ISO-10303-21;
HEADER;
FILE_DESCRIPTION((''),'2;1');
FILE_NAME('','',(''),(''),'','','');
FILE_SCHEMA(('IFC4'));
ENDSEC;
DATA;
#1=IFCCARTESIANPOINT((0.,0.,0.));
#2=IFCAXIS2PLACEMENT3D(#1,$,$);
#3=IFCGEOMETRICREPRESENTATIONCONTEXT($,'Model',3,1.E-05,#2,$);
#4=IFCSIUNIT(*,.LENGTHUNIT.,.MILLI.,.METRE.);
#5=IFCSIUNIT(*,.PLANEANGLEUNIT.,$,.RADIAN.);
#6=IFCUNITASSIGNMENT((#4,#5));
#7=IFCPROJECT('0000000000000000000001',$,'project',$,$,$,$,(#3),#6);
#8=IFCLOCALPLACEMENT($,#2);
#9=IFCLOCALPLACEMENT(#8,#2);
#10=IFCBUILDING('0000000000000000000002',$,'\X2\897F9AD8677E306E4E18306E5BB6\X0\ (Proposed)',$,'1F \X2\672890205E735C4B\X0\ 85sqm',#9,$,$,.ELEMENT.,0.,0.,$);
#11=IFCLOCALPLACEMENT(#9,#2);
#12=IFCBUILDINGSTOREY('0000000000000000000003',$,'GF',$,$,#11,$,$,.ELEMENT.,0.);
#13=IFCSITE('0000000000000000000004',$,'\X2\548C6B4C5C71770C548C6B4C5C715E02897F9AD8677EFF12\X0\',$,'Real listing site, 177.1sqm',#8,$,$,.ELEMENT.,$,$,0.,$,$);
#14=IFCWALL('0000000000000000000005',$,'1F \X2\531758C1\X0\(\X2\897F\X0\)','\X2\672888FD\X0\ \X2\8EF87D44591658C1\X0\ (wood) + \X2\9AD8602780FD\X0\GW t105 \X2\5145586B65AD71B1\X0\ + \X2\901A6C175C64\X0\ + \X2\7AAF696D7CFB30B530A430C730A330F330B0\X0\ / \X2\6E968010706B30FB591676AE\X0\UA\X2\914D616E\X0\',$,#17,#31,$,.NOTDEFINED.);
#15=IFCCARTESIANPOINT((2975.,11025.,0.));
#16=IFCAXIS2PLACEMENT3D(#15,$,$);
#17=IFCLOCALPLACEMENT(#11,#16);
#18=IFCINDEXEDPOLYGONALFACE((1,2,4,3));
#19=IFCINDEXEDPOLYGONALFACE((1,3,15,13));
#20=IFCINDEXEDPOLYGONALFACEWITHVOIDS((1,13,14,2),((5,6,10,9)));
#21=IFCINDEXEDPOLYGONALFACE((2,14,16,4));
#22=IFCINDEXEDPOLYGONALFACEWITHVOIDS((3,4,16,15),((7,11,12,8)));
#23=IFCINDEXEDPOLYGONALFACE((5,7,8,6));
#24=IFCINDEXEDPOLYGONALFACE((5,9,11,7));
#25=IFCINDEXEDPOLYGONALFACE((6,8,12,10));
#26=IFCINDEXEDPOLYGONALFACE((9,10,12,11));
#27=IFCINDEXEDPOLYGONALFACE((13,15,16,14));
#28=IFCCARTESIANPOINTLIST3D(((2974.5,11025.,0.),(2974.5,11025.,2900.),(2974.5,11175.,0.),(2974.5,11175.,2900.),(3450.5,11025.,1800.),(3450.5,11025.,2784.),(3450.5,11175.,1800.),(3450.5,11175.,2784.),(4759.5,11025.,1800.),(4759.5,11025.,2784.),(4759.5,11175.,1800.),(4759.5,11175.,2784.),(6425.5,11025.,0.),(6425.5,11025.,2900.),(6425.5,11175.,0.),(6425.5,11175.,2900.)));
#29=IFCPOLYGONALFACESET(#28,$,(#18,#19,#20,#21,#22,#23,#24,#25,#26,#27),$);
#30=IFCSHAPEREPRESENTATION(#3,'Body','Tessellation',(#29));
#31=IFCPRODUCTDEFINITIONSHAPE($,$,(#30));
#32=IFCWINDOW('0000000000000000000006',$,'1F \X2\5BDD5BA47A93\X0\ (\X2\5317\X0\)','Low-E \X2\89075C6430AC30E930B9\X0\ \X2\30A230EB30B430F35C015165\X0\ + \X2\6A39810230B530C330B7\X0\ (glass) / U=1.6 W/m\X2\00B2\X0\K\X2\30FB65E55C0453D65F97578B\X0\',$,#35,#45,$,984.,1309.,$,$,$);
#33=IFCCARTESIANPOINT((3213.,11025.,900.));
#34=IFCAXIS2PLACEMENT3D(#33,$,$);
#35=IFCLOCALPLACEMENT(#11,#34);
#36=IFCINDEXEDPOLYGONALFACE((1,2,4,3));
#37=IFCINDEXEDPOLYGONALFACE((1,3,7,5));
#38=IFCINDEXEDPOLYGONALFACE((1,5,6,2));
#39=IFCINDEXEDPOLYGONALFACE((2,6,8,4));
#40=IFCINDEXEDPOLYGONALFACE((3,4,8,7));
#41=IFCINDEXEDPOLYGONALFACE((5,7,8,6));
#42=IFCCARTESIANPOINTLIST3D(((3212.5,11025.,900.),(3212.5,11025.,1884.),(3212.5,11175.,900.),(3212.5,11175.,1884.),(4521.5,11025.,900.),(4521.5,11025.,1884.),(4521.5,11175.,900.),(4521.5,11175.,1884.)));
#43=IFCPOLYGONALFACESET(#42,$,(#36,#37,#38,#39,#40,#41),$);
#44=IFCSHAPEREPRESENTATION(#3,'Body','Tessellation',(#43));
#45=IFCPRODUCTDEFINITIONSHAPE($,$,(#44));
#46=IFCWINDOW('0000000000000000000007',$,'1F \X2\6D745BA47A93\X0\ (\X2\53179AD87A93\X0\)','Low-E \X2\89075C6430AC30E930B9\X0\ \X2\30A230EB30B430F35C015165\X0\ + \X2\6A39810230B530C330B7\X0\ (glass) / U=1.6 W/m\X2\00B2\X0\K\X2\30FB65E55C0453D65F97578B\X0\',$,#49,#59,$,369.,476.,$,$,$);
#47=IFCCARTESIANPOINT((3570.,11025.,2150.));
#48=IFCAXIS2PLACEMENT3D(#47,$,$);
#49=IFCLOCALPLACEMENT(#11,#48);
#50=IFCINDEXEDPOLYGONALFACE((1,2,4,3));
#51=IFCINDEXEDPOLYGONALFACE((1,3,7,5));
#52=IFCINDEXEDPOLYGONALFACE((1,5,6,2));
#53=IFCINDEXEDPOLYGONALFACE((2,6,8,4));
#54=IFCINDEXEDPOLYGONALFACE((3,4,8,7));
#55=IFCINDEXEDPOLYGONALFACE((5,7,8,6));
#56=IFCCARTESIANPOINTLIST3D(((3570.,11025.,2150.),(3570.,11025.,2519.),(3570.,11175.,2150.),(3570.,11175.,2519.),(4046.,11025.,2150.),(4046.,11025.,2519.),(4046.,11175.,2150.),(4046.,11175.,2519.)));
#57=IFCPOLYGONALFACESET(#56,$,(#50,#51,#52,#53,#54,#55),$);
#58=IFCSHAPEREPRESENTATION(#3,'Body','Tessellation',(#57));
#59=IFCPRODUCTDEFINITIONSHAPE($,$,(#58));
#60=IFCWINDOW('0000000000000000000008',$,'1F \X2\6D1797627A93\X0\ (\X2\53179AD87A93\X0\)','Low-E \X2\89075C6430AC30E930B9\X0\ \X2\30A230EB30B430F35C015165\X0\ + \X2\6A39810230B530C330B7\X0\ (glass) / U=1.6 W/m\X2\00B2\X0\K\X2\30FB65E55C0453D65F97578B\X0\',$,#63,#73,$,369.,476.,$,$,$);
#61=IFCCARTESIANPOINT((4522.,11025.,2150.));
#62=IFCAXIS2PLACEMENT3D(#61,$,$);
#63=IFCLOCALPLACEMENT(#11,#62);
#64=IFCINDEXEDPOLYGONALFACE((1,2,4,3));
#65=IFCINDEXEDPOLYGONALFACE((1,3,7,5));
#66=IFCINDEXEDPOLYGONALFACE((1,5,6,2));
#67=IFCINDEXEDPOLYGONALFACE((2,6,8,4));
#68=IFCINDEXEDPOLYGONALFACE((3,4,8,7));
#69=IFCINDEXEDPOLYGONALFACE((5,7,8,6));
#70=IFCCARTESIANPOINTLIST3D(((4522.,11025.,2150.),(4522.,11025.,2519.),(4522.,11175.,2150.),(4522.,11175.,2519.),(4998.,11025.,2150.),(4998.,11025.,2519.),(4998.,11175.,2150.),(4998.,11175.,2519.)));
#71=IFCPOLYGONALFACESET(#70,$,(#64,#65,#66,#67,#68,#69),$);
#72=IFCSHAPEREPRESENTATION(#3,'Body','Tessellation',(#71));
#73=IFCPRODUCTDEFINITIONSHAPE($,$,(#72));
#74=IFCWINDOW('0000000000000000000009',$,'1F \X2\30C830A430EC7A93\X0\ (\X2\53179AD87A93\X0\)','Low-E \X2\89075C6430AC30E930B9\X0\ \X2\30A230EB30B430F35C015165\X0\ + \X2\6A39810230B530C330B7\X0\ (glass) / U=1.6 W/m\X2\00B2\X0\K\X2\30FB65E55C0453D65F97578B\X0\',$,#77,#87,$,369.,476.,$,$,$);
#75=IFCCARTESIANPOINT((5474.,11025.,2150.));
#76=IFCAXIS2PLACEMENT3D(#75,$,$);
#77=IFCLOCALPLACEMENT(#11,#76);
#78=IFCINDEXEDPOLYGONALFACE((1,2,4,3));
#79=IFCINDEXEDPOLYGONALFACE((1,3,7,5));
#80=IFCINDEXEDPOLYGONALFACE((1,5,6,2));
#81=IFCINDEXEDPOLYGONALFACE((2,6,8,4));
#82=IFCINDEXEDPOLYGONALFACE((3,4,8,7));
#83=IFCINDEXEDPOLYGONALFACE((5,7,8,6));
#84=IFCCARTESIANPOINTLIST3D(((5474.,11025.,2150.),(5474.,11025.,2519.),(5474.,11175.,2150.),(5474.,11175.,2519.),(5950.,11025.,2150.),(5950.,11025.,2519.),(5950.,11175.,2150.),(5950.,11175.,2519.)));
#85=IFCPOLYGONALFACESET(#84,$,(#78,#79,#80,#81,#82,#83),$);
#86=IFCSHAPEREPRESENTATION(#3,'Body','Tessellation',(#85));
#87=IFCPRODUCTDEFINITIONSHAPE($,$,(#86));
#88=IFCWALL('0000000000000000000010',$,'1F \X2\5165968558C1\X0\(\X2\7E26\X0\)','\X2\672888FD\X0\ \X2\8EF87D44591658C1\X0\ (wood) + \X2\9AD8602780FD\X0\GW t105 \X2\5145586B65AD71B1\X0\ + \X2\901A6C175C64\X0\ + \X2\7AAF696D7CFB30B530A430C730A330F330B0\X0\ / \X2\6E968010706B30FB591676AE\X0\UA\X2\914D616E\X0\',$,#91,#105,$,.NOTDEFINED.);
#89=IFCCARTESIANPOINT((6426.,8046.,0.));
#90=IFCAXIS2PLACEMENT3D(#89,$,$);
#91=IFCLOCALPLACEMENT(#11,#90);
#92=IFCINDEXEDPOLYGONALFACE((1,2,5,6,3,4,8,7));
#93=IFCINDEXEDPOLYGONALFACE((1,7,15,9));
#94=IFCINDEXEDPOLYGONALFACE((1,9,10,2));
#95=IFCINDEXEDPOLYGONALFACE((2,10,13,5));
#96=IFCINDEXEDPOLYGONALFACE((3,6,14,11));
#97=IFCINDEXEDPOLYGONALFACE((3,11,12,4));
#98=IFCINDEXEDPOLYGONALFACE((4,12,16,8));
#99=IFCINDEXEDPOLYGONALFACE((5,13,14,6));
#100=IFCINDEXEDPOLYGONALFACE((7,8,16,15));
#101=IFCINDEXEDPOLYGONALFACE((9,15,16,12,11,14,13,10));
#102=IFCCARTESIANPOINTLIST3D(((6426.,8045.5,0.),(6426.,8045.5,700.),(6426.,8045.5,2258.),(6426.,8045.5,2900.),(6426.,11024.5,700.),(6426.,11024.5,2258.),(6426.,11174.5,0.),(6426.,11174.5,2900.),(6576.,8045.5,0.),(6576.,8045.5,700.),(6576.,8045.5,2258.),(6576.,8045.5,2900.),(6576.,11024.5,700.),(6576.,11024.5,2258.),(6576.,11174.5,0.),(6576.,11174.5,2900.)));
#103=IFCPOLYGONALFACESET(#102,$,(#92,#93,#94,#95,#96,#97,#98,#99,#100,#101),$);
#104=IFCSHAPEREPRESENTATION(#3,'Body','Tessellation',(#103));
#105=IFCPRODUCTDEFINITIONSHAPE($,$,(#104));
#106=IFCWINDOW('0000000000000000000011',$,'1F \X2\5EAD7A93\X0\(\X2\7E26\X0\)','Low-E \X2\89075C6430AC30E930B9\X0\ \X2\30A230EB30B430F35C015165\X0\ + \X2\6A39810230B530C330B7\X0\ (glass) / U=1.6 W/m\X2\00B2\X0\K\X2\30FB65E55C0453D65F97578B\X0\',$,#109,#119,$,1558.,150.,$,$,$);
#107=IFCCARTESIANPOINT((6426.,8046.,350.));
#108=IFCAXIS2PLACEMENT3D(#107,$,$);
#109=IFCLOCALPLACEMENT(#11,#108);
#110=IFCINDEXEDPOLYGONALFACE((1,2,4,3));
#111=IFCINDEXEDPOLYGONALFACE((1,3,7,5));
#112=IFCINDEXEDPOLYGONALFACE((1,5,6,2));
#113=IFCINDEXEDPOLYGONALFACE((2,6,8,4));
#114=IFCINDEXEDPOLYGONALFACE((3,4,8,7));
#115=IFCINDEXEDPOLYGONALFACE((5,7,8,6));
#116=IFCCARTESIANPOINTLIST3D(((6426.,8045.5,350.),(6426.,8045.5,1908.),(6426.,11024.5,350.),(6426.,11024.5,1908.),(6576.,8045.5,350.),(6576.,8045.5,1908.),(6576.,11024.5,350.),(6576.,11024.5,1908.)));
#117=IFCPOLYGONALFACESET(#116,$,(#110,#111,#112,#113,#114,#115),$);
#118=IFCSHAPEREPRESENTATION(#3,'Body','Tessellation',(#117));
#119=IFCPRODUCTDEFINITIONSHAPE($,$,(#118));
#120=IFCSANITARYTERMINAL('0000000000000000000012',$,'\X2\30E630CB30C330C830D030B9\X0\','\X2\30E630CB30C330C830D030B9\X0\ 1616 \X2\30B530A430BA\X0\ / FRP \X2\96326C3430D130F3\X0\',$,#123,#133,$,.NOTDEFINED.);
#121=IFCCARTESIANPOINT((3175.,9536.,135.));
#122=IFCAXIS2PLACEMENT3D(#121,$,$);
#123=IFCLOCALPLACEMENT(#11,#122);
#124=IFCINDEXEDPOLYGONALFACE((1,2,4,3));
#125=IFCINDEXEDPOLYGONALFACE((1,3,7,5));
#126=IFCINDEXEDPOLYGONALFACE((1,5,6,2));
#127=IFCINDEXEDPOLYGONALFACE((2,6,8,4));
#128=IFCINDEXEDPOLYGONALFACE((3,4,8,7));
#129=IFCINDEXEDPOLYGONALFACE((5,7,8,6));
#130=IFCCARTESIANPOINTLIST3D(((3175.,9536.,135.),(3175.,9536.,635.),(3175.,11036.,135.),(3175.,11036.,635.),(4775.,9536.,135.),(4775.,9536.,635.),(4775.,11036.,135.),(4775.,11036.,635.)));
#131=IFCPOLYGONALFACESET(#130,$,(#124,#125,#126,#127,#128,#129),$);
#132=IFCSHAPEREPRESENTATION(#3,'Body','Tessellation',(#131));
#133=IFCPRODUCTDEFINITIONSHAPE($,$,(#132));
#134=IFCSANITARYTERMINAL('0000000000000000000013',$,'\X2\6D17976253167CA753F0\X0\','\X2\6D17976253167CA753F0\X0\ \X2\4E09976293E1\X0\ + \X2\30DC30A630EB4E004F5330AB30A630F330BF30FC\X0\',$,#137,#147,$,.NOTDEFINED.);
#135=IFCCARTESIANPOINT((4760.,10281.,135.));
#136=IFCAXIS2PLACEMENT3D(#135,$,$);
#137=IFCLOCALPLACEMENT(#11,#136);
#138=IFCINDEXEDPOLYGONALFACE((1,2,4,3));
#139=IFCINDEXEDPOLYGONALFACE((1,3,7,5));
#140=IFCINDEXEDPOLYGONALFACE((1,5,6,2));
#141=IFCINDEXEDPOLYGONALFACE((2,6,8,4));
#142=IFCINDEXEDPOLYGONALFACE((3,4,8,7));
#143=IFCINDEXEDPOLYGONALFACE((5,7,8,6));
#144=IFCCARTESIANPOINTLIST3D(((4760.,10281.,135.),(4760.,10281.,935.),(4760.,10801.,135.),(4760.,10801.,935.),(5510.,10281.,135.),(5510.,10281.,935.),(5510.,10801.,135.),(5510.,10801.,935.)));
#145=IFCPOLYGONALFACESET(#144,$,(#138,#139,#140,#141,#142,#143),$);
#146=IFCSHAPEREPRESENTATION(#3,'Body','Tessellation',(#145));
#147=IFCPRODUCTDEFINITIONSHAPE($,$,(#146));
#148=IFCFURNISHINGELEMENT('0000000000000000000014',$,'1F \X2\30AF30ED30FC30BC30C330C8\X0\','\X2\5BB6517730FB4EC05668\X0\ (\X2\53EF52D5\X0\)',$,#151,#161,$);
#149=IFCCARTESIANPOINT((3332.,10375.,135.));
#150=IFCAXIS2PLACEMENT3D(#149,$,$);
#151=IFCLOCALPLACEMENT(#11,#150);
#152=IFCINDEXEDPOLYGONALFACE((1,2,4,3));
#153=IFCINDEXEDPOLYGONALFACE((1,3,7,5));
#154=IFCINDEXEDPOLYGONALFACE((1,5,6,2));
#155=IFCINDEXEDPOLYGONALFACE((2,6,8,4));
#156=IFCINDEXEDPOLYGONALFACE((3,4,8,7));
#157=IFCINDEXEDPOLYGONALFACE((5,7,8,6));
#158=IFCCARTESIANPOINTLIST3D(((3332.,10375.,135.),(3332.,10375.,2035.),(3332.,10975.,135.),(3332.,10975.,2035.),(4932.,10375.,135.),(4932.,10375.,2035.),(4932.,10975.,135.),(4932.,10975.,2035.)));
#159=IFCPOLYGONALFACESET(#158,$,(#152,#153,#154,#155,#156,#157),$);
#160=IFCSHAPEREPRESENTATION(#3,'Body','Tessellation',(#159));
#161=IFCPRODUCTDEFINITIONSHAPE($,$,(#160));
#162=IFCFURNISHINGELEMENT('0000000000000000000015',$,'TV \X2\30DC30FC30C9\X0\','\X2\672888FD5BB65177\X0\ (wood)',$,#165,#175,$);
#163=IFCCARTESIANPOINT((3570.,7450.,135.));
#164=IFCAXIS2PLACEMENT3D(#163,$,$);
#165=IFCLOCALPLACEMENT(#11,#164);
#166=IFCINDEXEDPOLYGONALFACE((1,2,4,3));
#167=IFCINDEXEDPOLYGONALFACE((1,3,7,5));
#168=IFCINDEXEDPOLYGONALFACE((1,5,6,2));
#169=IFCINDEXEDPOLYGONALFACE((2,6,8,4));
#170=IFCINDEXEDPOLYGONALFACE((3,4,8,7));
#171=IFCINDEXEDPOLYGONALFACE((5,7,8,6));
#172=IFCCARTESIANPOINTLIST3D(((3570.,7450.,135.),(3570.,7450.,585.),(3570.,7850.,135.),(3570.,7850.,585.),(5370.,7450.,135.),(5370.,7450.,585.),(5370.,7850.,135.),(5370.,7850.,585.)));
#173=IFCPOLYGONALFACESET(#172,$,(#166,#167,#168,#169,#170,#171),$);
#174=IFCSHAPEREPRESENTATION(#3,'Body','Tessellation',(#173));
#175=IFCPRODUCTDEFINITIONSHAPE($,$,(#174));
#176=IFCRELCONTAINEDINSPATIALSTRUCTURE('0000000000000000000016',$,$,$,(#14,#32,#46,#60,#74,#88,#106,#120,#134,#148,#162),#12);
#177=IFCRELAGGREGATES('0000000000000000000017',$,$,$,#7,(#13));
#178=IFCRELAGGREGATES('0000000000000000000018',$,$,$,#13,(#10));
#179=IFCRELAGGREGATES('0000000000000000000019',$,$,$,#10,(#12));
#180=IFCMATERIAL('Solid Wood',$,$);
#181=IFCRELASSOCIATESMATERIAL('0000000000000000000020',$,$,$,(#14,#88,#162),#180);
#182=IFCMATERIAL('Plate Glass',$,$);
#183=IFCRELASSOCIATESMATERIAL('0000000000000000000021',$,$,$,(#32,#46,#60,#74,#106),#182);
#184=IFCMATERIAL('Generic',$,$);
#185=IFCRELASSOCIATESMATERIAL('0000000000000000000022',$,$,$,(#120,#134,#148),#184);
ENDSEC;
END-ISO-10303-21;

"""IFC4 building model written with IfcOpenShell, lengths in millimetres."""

from ifc_helpers import new_model, si_unit, frame, frame_2d, origin, place, context, project, spatial, rectangle, extrude, material, element, fill, save


model = new_model("IFC4")

# Units and contexts
model_context = context("Model", 3, precision=1e-05, world=origin())
ifc_project = project(units=[si_unit("LENGTHUNIT", "METRE", prefix="MILLI"), si_unit("PLANEANGLEUNIT", "RADIAN")], contexts=[model_context])

# Site, building, storey
site_placement = place(None, origin())
site = spatial("IfcSite", under=ifc_project, at=site_placement, Name="和歌山県和歌山市西高松２", ObjectType="Real listing site, 177.1sqm", CompositionType="ELEMENT", RefElevation=0.0)
building_placement = place(site_placement, origin())
building = spatial("IfcBuilding", under=site, at=building_placement, Name="西高松の丘の家 (Proposed)", ObjectType="1F 木造平屋 85sqm", CompositionType="ELEMENT", ElevationOfRefHeight=0.0, ElevationOfTerrain=0.0)
storey_placement = place(building_placement, origin())
storey = spatial("IfcBuildingStorey", under=building, at=storey_placement, Name="GF", CompositionType="ELEMENT", Elevation=0.0)

# Shared definitions
ifc_material_1 = material(Name="Solid Wood")

# Wall, openings, windows
wall_1_placement = place(storey_placement, frame((2975.0, 11025.0, 0.0)))
wall_1 = element("IfcWall", 1, at=wall_1_placement, inside=storey, material=ifc_material_1, Name="1F 北壁(西)", Description="木製 軸組外壁 (wood) + 高性能GW t105 充填断熱 + 通気層 + 窯業系サイディング / 準耐火・外皮UA配慮", PredefinedType="NOTDEFINED", context=model_context, shape_type="SweptSolid", body=[
    extrude(rectangle(XDim=3451.0, YDim=150.0, at=frame_2d((1725.0, 75.0))), frame((2975.0, 11025.0, 0.0)), (0.0, 0.0, 1.0), 2900.0),
])
opening_1_placement = place(storey_placement, frame((3213.0, 11025.0, 900.0)))
opening_1 = element("IfcOpeningElement", 2, at=opening_1_placement, cuts=wall_1, PredefinedType="NOTDEFINED", context=model_context, shape_type="SweptSolid", body=[
    extrude(rectangle(XDim=1309.0, YDim=150.0, at=frame_2d((654.0, 75.0))), frame((3213.0, 11025.0, 900.0)), (0.0, 0.0, 1.0), 984.0),
])
opening_2_placement = place(storey_placement, frame((3570.0, 11025.0, 2150.0)))
opening_2 = element("IfcOpeningElement", 3, at=opening_2_placement, cuts=wall_1, PredefinedType="NOTDEFINED", context=model_context, shape_type="SweptSolid", body=[
    extrude(rectangle(XDim=476.0, YDim=150.0, at=frame_2d((238.0, 75.0))), frame((3570.0, 11025.0, 2150.0)), (0.0, 0.0, 1.0), 369.0),
])
opening_3_placement = place(storey_placement, frame((4522.0, 11025.0, 2150.0)))
opening_3 = element("IfcOpeningElement", 4, at=opening_3_placement, cuts=wall_1, PredefinedType="NOTDEFINED", context=model_context, shape_type="SweptSolid", body=[
    extrude(rectangle(XDim=476.0, YDim=150.0, at=frame_2d((238.0, 75.0))), frame((4522.0, 11025.0, 2150.0)), (0.0, 0.0, 1.0), 369.0),
])
opening_4_placement = place(storey_placement, frame((5474.0, 11025.0, 2150.0)))
opening_4 = element("IfcOpeningElement", 5, at=opening_4_placement, cuts=wall_1, PredefinedType="NOTDEFINED", context=model_context, shape_type="SweptSolid", body=[
    extrude(rectangle(XDim=476.0, YDim=150.0, at=frame_2d((238.0, 75.0))), frame((5474.0, 11025.0, 2150.0)), (0.0, 0.0, 1.0), 369.0),
])
ifc_material_2 = material(Name="Plate Glass")
window_1_placement = place(storey_placement, frame((3213.0, 11025.0, 900.0)))
window_1 = element("IfcWindow", 6, at=window_1_placement, inside=storey, material=ifc_material_2, Name="1F 寝室窓 (北)", Description="Low-E 複層ガラス アルゴン封入 + 樹脂サッシ (glass) / U=1.6 W/m²K・日射取得型", OverallHeight=984.0, OverallWidth=1309.0, context=model_context, shape_type="SweptSolid", body=[
    extrude(rectangle(XDim=1309.0, YDim=150.0, at=frame_2d((654.0, 75.0))), frame((3213.0, 11025.0, 900.0)), (0.0, 0.0, 1.0), 984.0),
])
fill(opening_1, window_1)
window_2_placement = place(storey_placement, frame((3570.0, 11025.0, 2150.0)))
window_2 = element("IfcWindow", 7, at=window_2_placement, inside=storey, material=ifc_material_2, Name="1F 浴室窓 (北高窓)", Description="Low-E 複層ガラス アルゴン封入 + 樹脂サッシ (glass) / U=1.6 W/m²K・日射取得型", OverallHeight=369.0, OverallWidth=476.0, context=model_context, shape_type="SweptSolid", body=[
    extrude(rectangle(XDim=476.0, YDim=150.0, at=frame_2d((238.0, 75.0))), frame((3570.0, 11025.0, 2150.0)), (0.0, 0.0, 1.0), 369.0),
])
fill(opening_2, window_2)
window_3_placement = place(storey_placement, frame((4522.0, 11025.0, 2150.0)))
window_3 = element("IfcWindow", 8, at=window_3_placement, inside=storey, material=ifc_material_2, Name="1F 洗面窓 (北高窓)", Description="Low-E 複層ガラス アルゴン封入 + 樹脂サッシ (glass) / U=1.6 W/m²K・日射取得型", OverallHeight=369.0, OverallWidth=476.0, context=model_context, shape_type="SweptSolid", body=[
    extrude(rectangle(XDim=476.0, YDim=150.0, at=frame_2d((238.0, 75.0))), frame((4522.0, 11025.0, 2150.0)), (0.0, 0.0, 1.0), 369.0),
])
fill(opening_3, window_3)
window_4_placement = place(storey_placement, frame((5474.0, 11025.0, 2150.0)))
window_4 = element("IfcWindow", 9, at=window_4_placement, inside=storey, material=ifc_material_2, Name="1F トイレ窓 (北高窓)", Description="Low-E 複層ガラス アルゴン封入 + 樹脂サッシ (glass) / U=1.6 W/m²K・日射取得型", OverallHeight=369.0, OverallWidth=476.0, context=model_context, shape_type="SweptSolid", body=[
    extrude(rectangle(XDim=476.0, YDim=150.0, at=frame_2d((238.0, 75.0))), frame((5474.0, 11025.0, 2150.0)), (0.0, 0.0, 1.0), 369.0),
])
fill(opening_4, window_4)

# Wall, opening, window
wall_2_placement = place(storey_placement, frame((6426.0, 8046.0, 0.0)))
wall_2 = element("IfcWall", 10, at=wall_2_placement, inside=storey, material=ifc_material_1, Name="1F 入隅壁(縦)", Description="木製 軸組外壁 (wood) + 高性能GW t105 充填断熱 + 通気層 + 窯業系サイディング / 準耐火・外皮UA配慮", PredefinedType="NOTDEFINED", context=model_context, shape_type="SweptSolid", body=[
    extrude(rectangle(XDim=150.0, YDim=3129.0, at=frame_2d((75.0, 1564.0))), frame((6426.0, 8046.0, 0.0)), (0.0, 0.0, 1.0), 2900.0),
])
opening_5_placement = place(storey_placement, frame((6426.0, 8046.0, 350.0)))
opening_5 = element("IfcOpeningElement", 11, at=opening_5_placement, cuts=wall_2, PredefinedType="NOTDEFINED", context=model_context, shape_type="SweptSolid", body=[
    extrude(rectangle(XDim=150.0, YDim=2979.0, at=frame_2d((75.0, 1489.0))), frame((6426.0, 8046.0, 350.0)), (0.0, 0.0, 1.0), 1558.0),
])
window_5_placement = place(storey_placement, frame((6426.0, 8046.0, 350.0)))
window_5 = element("IfcWindow", 12, at=window_5_placement, inside=storey, material=ifc_material_2, Name="1F 庭窓(縦)", Description="Low-E 複層ガラス アルゴン封入 + 樹脂サッシ (glass) / U=1.6 W/m²K・日射取得型", OverallHeight=1558.0, OverallWidth=150.0, context=model_context, shape_type="SweptSolid", body=[
    extrude(rectangle(XDim=150.0, YDim=2979.0, at=frame_2d((75.0, 1489.0))), frame((6426.0, 8046.0, 350.0)), (0.0, 0.0, 1.0), 1558.0),
])
fill(opening_5, window_5)

# Shared definitions
ifc_material_3 = material(Name="Generic")

# Sanitary terminals
sanitary_terminal_1_placement = place(storey_placement, frame((3175.0, 9536.0, 135.0)))
element("IfcSanitaryTerminal", 13, at=sanitary_terminal_1_placement, inside=storey, material=ifc_material_3, Name="ユニットバス", Description="ユニットバス 1616 サイズ / FRP 防水パン", PredefinedType="NOTDEFINED", context=model_context, shape_type="SweptSolid", body=[
    extrude(rectangle(XDim=1600.0, YDim=1500.0, at=frame_2d((800.0, 750.0))), frame((3175.0, 9536.0, 135.0)), (0.0, 0.0, 1.0), 500.0),
])
sanitary_terminal_2_placement = place(storey_placement, frame((4760.0, 10281.0, 135.0)))
element("IfcSanitaryTerminal", 14, at=sanitary_terminal_2_placement, inside=storey, material=ifc_material_3, Name="洗面化粧台", Description="洗面化粧台 三面鏡 + ボウル一体カウンター", PredefinedType="NOTDEFINED", context=model_context, shape_type="SweptSolid", body=[
    extrude(rectangle(XDim=750.0, YDim=520.0, at=frame_2d((375.0, 260.0))), frame((4760.0, 10281.0, 135.0)), (0.0, 0.0, 1.0), 800.0),
])

# Furnishing elements
furnishing_1_placement = place(storey_placement, frame((3332.0, 10375.0, 135.0)))
element("IfcFurnishingElement", 15, at=furnishing_1_placement, inside=storey, material=ifc_material_3, Name="1F クローゼット", Description="家具・什器 (可動)", context=model_context, shape_type="SweptSolid", body=[
    extrude(rectangle(XDim=1600.0, YDim=600.0, at=frame_2d((800.0, 300.0))), frame((3332.0, 10375.0, 135.0)), (0.0, 0.0, 1.0), 1900.0),
])
furnishing_2_placement = place(storey_placement, frame((3570.0, 7450.0, 135.0)))
element("IfcFurnishingElement", 16, at=furnishing_2_placement, inside=storey, material=ifc_material_1, Name="TV ボード", Description="木製家具 (wood)", context=model_context, shape_type="SweptSolid", body=[
    extrude(rectangle(XDim=1800.0, YDim=400.0, at=frame_2d((900.0, 200.0))), frame((3570.0, 7450.0, 135.0)), (0.0, 0.0, 1.0), 450.0),
])

save(model, "model.ifc")
